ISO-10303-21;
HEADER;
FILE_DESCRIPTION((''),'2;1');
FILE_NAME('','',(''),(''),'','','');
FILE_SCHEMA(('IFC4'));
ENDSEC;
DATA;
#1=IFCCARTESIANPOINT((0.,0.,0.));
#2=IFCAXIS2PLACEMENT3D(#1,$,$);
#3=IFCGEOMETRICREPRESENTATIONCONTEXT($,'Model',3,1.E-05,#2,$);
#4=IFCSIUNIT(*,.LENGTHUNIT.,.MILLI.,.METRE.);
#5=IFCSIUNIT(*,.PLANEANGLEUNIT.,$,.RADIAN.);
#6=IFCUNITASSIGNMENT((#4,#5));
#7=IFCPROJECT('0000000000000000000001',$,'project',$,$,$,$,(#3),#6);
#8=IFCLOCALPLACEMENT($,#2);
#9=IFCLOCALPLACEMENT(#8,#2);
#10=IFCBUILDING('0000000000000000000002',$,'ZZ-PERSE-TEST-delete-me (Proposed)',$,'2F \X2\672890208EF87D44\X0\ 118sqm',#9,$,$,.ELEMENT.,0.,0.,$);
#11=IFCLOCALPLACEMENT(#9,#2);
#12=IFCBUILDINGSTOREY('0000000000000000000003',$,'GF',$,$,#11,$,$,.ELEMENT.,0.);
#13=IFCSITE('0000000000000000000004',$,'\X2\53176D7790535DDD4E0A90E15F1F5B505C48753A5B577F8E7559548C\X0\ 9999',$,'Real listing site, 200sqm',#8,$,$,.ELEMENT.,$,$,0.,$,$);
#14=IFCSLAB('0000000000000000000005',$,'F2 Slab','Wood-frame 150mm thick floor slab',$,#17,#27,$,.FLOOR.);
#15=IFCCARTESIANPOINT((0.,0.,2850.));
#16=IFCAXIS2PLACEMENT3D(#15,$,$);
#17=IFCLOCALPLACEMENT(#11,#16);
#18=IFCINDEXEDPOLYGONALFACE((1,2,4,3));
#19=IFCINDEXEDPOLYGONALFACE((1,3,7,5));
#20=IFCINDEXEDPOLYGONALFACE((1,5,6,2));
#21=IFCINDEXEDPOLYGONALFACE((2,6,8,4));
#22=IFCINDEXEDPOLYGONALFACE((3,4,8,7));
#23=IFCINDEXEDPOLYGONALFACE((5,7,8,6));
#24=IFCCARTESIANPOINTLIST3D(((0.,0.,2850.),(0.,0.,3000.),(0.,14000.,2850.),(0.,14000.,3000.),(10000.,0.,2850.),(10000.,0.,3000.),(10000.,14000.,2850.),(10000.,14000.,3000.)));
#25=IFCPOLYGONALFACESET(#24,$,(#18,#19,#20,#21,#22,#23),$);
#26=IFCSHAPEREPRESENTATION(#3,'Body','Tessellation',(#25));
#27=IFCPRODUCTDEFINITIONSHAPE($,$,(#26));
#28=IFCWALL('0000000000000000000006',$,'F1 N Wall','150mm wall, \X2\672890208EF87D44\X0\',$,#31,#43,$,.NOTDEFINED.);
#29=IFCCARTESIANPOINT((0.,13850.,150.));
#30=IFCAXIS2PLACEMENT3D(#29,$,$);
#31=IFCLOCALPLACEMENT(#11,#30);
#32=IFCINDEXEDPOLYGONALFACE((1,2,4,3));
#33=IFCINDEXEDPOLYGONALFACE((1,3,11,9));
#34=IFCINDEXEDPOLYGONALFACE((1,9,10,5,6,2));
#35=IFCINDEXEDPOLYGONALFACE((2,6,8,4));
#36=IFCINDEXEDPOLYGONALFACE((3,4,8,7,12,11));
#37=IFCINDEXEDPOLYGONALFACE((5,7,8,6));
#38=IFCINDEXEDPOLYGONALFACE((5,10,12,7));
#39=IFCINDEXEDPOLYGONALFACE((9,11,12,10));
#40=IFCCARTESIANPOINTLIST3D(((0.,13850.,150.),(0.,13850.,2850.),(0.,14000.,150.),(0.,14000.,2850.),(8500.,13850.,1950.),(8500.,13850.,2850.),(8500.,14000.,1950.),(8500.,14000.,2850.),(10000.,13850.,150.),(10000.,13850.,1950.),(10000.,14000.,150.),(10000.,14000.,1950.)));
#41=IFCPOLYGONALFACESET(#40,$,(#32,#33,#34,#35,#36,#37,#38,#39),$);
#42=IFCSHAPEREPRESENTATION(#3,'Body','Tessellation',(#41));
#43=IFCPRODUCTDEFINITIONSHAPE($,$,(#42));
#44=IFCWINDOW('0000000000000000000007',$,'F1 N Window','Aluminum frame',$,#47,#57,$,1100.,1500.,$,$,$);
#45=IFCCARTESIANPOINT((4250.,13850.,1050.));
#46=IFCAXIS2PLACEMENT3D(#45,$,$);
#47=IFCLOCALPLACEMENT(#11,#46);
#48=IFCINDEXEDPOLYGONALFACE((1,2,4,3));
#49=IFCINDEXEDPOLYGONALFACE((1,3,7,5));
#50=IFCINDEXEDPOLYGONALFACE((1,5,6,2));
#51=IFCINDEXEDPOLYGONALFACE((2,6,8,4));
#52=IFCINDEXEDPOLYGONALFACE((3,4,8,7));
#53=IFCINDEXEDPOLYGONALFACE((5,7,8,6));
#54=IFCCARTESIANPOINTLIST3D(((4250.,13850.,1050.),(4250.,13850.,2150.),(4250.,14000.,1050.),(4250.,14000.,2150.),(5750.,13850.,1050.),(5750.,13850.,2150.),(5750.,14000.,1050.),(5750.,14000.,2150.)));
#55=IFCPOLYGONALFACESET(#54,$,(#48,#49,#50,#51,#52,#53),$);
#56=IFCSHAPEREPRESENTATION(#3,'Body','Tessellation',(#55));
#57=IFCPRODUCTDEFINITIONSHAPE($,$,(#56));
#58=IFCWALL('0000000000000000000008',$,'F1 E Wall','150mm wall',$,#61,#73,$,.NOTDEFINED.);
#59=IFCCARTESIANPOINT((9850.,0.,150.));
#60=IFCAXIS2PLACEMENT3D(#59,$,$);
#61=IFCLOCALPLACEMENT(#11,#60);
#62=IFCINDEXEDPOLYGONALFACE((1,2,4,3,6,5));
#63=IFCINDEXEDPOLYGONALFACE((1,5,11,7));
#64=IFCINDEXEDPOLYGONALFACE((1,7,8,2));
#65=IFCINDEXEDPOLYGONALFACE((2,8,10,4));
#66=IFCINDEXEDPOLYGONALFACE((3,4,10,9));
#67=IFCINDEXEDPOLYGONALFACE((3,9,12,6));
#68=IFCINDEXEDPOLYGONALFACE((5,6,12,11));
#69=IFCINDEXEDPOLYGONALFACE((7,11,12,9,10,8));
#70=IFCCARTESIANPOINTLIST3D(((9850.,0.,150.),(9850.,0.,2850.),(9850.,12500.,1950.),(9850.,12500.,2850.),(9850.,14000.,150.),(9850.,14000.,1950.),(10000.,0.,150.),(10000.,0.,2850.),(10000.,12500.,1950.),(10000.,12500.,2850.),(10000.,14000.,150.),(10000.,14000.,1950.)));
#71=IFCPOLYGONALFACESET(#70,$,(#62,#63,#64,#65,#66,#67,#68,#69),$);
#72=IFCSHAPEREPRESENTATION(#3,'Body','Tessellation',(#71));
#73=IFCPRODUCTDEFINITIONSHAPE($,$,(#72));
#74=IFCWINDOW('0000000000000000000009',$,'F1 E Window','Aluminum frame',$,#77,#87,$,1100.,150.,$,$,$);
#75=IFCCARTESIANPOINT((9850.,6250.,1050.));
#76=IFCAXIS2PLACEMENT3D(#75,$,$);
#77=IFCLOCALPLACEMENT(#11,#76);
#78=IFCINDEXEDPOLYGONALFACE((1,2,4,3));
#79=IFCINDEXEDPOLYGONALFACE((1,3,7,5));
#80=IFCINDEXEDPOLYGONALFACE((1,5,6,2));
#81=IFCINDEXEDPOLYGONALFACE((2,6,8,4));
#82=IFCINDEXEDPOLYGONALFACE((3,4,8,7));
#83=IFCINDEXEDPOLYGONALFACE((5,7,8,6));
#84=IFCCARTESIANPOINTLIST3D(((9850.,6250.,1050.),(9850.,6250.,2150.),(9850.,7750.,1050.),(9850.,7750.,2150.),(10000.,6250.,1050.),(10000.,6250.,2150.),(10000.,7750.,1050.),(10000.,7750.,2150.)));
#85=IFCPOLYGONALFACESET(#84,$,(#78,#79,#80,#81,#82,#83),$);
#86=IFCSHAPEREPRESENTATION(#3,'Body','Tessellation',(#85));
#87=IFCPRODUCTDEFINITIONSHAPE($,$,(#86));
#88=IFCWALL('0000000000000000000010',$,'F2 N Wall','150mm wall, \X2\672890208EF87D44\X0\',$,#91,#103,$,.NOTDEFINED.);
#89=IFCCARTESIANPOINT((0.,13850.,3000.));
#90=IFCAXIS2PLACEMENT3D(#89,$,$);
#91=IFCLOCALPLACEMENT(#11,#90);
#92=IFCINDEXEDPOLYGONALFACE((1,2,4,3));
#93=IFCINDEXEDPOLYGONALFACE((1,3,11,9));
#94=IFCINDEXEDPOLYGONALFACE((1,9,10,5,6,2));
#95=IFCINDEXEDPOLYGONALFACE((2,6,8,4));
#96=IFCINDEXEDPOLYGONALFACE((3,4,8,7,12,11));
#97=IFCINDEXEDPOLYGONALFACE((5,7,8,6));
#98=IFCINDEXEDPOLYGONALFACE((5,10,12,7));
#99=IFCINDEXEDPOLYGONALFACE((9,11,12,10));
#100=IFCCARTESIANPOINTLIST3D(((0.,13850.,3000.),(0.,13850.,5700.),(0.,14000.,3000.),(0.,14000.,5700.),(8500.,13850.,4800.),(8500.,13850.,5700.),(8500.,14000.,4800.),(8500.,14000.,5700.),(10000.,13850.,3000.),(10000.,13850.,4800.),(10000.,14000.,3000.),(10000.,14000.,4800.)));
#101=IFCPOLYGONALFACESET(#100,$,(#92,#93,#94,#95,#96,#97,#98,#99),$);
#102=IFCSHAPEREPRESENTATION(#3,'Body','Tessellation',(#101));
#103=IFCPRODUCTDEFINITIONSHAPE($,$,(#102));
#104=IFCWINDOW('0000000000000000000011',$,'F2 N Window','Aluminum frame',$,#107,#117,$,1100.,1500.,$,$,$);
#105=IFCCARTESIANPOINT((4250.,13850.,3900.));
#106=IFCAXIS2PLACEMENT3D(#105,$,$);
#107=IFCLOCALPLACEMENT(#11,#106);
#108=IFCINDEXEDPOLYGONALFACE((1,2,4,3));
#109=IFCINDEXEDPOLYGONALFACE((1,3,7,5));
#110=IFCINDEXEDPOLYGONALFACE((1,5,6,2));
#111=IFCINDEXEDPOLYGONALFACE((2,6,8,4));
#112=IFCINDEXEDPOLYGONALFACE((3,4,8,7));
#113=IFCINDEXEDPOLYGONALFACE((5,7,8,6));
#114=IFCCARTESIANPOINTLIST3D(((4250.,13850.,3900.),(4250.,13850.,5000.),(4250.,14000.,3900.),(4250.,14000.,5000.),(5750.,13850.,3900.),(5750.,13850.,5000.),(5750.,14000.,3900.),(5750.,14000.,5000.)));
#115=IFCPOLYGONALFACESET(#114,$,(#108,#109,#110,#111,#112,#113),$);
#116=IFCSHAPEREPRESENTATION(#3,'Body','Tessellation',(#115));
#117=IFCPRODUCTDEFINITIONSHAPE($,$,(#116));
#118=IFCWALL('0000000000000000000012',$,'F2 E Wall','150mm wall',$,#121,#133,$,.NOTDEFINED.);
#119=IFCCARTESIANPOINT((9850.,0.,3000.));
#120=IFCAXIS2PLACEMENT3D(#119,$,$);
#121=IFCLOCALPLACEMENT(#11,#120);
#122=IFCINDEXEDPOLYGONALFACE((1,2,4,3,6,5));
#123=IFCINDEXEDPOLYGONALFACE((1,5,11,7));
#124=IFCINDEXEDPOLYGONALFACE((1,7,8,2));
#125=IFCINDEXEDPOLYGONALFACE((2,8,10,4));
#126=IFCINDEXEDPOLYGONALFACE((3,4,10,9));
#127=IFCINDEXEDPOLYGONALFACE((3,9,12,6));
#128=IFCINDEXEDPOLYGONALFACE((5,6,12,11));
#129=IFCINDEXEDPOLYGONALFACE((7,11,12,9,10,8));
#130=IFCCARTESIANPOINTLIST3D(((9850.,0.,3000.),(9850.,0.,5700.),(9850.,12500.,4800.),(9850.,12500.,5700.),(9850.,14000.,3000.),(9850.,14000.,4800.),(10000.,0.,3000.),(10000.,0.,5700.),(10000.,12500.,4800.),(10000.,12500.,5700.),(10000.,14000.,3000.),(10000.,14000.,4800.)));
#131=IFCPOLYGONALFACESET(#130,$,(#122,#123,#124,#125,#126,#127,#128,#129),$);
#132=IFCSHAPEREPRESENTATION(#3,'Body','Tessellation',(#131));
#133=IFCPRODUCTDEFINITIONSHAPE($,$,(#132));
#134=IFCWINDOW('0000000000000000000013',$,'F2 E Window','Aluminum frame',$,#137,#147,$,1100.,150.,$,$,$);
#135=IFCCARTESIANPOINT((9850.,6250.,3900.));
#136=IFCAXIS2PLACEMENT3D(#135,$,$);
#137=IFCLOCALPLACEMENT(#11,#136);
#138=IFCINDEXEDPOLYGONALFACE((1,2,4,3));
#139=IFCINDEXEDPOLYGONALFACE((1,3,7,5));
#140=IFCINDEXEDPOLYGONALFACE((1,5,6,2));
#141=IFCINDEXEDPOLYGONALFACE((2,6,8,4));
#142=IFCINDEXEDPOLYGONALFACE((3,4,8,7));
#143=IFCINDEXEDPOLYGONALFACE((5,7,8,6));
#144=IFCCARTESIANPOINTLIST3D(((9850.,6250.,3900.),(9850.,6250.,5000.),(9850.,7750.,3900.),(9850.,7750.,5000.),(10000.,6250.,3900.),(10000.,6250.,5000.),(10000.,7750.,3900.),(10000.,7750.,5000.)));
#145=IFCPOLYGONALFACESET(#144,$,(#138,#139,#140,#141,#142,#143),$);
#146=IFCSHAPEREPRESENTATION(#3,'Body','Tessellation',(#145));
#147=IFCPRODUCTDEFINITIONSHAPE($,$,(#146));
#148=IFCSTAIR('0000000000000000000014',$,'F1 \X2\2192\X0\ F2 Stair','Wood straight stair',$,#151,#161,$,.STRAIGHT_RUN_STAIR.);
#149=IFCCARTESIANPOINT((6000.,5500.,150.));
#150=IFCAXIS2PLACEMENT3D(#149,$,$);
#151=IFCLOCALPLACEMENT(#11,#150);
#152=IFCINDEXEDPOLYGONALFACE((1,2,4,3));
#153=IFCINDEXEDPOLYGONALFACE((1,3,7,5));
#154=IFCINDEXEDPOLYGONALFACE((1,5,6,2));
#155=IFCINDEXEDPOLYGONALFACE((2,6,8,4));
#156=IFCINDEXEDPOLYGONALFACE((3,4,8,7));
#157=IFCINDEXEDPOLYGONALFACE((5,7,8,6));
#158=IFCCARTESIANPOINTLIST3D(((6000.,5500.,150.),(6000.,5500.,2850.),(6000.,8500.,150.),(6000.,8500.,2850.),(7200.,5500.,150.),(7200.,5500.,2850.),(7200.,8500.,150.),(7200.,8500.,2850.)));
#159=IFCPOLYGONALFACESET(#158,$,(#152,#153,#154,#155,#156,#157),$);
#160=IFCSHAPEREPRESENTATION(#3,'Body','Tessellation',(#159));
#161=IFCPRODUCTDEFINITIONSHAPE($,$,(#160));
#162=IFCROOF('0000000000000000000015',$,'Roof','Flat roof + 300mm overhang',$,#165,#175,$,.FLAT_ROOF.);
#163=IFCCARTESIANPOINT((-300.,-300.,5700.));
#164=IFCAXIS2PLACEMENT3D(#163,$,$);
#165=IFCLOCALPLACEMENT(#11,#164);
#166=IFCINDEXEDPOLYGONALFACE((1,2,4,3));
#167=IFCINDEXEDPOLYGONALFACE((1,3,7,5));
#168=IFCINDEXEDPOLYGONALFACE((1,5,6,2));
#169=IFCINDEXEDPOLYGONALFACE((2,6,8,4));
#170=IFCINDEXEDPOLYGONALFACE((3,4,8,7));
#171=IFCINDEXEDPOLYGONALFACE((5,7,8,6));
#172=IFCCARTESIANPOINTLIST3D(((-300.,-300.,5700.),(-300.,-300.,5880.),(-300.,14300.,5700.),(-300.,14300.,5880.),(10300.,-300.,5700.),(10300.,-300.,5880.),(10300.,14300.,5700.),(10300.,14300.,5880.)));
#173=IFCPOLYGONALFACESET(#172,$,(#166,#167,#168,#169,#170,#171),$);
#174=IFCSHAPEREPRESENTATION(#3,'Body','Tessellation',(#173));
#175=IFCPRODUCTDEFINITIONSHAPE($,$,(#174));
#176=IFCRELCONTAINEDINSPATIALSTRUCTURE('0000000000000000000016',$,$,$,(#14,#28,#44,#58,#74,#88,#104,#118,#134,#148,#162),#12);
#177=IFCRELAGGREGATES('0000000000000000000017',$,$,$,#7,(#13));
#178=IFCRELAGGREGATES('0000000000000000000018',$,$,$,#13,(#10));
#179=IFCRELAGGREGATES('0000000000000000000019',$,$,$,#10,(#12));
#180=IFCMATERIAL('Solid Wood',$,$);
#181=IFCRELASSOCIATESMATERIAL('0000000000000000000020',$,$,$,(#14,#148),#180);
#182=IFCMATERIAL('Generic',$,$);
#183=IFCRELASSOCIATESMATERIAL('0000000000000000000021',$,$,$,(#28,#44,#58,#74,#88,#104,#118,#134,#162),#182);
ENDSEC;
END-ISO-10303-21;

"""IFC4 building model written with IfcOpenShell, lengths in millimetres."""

from ifc_helpers import new_model, si_unit, frame, frame_2d, origin, place, context, project, spatial, rectangle, extrude, material, element, fill, save


model = new_model("IFC4")

# Units and contexts
model_context = context("Model", 3, precision=1e-05, world=origin())
ifc_project = project(units=[si_unit("LENGTHUNIT", "METRE", prefix="MILLI"), si_unit("PLANEANGLEUNIT", "RADIAN")], contexts=[model_context])

# Site, building, storey
site_placement = place(None, origin())
site = spatial("IfcSite", under=ifc_project, at=site_placement, Name="北海道川上郡弟子屈町字美留和 9999", ObjectType="Real listing site, 200sqm", CompositionType="ELEMENT", RefElevation=0.0)
building_placement = place(site_placement, origin())
building = spatial("IfcBuilding", under=site, at=building_placement, Name="ZZ-PERSE-TEST-delete-me (Proposed)", ObjectType="2F 木造軸組 118sqm", CompositionType="ELEMENT", ElevationOfRefHeight=0.0, ElevationOfTerrain=0.0)
storey_placement = place(building_placement, origin())
storey = spatial("IfcBuildingStorey", under=building, at=storey_placement, Name="GF", CompositionType="ELEMENT", Elevation=0.0)

# Slab
ifc_material_1 = material(Name="Solid Wood")
slab_1_placement = place(storey_placement, frame((0.0, 0.0, 2850.0)))
element("IfcSlab", 1, at=slab_1_placement, inside=storey, material=ifc_material_1, Name="F2 Slab", Description="Wood-frame 150mm thick floor slab", PredefinedType="FLOOR", context=model_context, shape_type="SweptSolid", body=[
    extrude(rectangle(XDim=10000.0, YDim=14000.0, at=frame_2d((5000.0, 7000.0))), frame((0.0, 0.0, 2850.0)), (0.0, 0.0, 1.0), 150.0),
])

# Wall, opening, window
ifc_material_2 = material(Name="Generic")
wall_1_placement = place(storey_placement, frame((0.0, 13850.0, 150.0)))
wall_1 = element("IfcWall", 2, at=wall_1_placement, inside=storey, material=ifc_material_2, Name="F1 N Wall", Description="150mm wall, 木造軸組", PredefinedType="NOTDEFINED", context=model_context, shape_type="SweptSolid", body=[
    extrude(rectangle(XDim=10000.0, YDim=150.0, at=frame_2d((5000.0, 75.0))), frame((0.0, 13850.0, 150.0)), (0.0, 0.0, 1.0), 2700.0),
])
opening_1_placement = place(storey_placement, frame((4250.0, 13850.0, 1050.0)))
opening_1 = element("IfcOpeningElement", 3, at=opening_1_placement, cuts=wall_1, PredefinedType="NOTDEFINED", context=model_context, shape_type="SweptSolid", body=[
    extrude(rectangle(XDim=1500.0, YDim=150.0, at=frame_2d((750.0, 75.0))), frame((4250.0, 13850.0, 1050.0)), (0.0, 0.0, 1.0), 1100.0),
])
window_1_placement = place(storey_placement, frame((4250.0, 13850.0, 1050.0)))
window_1 = element("IfcWindow", 4, at=window_1_placement, inside=storey, material=ifc_material_2, Name="F1 N Window", Description="Aluminum frame", OverallHeight=1100.0, OverallWidth=1500.0, context=model_context, shape_type="SweptSolid", body=[
    extrude(rectangle(XDim=1500.0, YDim=150.0, at=frame_2d((750.0, 75.0))), frame((4250.0, 13850.0, 1050.0)), (0.0, 0.0, 1.0), 1100.0),
])
fill(opening_1, window_1)

# Walls, openings, windows
wall_2_placement = place(storey_placement, frame((9850.0, 0.0, 150.0)))
wall_2 = element("IfcWall", 5, at=wall_2_placement, inside=storey, material=ifc_material_2, Name="F1 E Wall", Description="150mm wall", PredefinedType="NOTDEFINED", context=model_context, shape_type="SweptSolid", body=[
    extrude(rectangle(XDim=150.0, YDim=14000.0, at=frame_2d((75.0, 7000.0))), frame((9850.0, 0.0, 150.0)), (0.0, 0.0, 1.0), 2700.0),
])
opening_2_placement = place(storey_placement, frame((9850.0, 6250.0, 1050.0)))
opening_2 = element("IfcOpeningElement", 6, at=opening_2_placement, cuts=wall_2, PredefinedType="NOTDEFINED", context=model_context, shape_type="SweptSolid", body=[
    extrude(rectangle(XDim=150.0, YDim=1500.0, at=frame_2d((75.0, 750.0))), frame((9850.0, 6250.0, 1050.0)), (0.0, 0.0, 1.0), 1100.0),
])
window_2_placement = place(storey_placement, frame((9850.0, 6250.0, 1050.0)))
window_2 = element("IfcWindow", 7, at=window_2_placement, inside=storey, material=ifc_material_2, Name="F1 E Window", Description="Aluminum frame", OverallHeight=1100.0, OverallWidth=150.0, context=model_context, shape_type="SweptSolid", body=[
    extrude(rectangle(XDim=150.0, YDim=1500.0, at=frame_2d((75.0, 750.0))), frame((9850.0, 6250.0, 1050.0)), (0.0, 0.0, 1.0), 1100.0),
])
fill(opening_2, window_2)
wall_3_placement = place(storey_placement, frame((0.0, 13850.0, 3000.0)))
wall_3 = element("IfcWall", 8, at=wall_3_placement, inside=storey, material=ifc_material_2, Name="F2 N Wall", Description="150mm wall, 木造軸組", PredefinedType="NOTDEFINED", context=model_context, shape_type="SweptSolid", body=[
    extrude(rectangle(XDim=10000.0, YDim=150.0, at=frame_2d((5000.0, 75.0))), frame((0.0, 13850.0, 3000.0)), (0.0, 0.0, 1.0), 2700.0),
])
opening_3_placement = place(storey_placement, frame((4250.0, 13850.0, 3900.0)))
opening_3 = element("IfcOpeningElement", 9, at=opening_3_placement, cuts=wall_3, PredefinedType="NOTDEFINED", context=model_context, shape_type="SweptSolid", body=[
    extrude(rectangle(XDim=1500.0, YDim=150.0, at=frame_2d((750.0, 75.0))), frame((4250.0, 13850.0, 3900.0)), (0.0, 0.0, 1.0), 1100.0),
])
window_3_placement = place(storey_placement, frame((4250.0, 13850.0, 3900.0)))
window_3 = element("IfcWindow", 10, at=window_3_placement, inside=storey, material=ifc_material_2, Name="F2 N Window", Description="Aluminum frame", OverallHeight=1100.0, OverallWidth=1500.0, context=model_context, shape_type="SweptSolid", body=[
    extrude(rectangle(XDim=1500.0, YDim=150.0, at=frame_2d((750.0, 75.0))), frame((4250.0, 13850.0, 3900.0)), (0.0, 0.0, 1.0), 1100.0),
])
fill(opening_3, window_3)
wall_4_placement = place(storey_placement, frame((9850.0, 0.0, 3000.0)))
wall_4 = element("IfcWall", 11, at=wall_4_placement, inside=storey, material=ifc_material_2, Name="F2 E Wall", Description="150mm wall", PredefinedType="NOTDEFINED", context=model_context, shape_type="SweptSolid", body=[
    extrude(rectangle(XDim=150.0, YDim=14000.0, at=frame_2d((75.0, 7000.0))), frame((9850.0, 0.0, 3000.0)), (0.0, 0.0, 1.0), 2700.0),
])
opening_4_placement = place(storey_placement, frame((9850.0, 6250.0, 3900.0)))
opening_4 = element("IfcOpeningElement", 12, at=opening_4_placement, cuts=wall_4, PredefinedType="NOTDEFINED", context=model_context, shape_type="SweptSolid", body=[
    extrude(rectangle(XDim=150.0, YDim=1500.0, at=frame_2d((75.0, 750.0))), frame((9850.0, 6250.0, 3900.0)), (0.0, 0.0, 1.0), 1100.0),
])
window_4_placement = place(storey_placement, frame((9850.0, 6250.0, 3900.0)))
window_4 = element("IfcWindow", 13, at=window_4_placement, inside=storey, material=ifc_material_2, Name="F2 E Window", Description="Aluminum frame", OverallHeight=1100.0, OverallWidth=150.0, context=model_context, shape_type="SweptSolid", body=[
    extrude(rectangle(XDim=150.0, YDim=1500.0, at=frame_2d((75.0, 750.0))), frame((9850.0, 6250.0, 3900.0)), (0.0, 0.0, 1.0), 1100.0),
])
fill(opening_4, window_4)

# Stair
stair_placement = place(storey_placement, frame((6000.0, 5500.0, 150.0)))
element("IfcStair", 14, at=stair_placement, inside=storey, material=ifc_material_1, Name="F1 → F2 Stair", Description="Wood straight stair", PredefinedType="STRAIGHT_RUN_STAIR", context=model_context, shape_type="SweptSolid", body=[
    extrude(rectangle(XDim=1200.0, YDim=3000.0, at=frame_2d((600.0, 1500.0))), frame((6000.0, 5500.0, 150.0)), (0.0, 0.0, 1.0), 2700.0),
])

# Roof
roof_placement = place(storey_placement, frame((-300.0, -300.0, 5700.0)))
element("IfcRoof", 15, at=roof_placement, inside=storey, material=ifc_material_2, Name="Roof", Description="Flat roof + 300mm overhang", PredefinedType="FLAT_ROOF", context=model_context, shape_type="SweptSolid", body=[
    extrude(rectangle(XDim=10600.0, YDim=14600.0, at=frame_2d((5300.0, 7300.0))), frame((-300.0, -300.0, 5700.0)), (0.0, 0.0, 1.0), 180.0),
])

save(model, "model.ifc")
